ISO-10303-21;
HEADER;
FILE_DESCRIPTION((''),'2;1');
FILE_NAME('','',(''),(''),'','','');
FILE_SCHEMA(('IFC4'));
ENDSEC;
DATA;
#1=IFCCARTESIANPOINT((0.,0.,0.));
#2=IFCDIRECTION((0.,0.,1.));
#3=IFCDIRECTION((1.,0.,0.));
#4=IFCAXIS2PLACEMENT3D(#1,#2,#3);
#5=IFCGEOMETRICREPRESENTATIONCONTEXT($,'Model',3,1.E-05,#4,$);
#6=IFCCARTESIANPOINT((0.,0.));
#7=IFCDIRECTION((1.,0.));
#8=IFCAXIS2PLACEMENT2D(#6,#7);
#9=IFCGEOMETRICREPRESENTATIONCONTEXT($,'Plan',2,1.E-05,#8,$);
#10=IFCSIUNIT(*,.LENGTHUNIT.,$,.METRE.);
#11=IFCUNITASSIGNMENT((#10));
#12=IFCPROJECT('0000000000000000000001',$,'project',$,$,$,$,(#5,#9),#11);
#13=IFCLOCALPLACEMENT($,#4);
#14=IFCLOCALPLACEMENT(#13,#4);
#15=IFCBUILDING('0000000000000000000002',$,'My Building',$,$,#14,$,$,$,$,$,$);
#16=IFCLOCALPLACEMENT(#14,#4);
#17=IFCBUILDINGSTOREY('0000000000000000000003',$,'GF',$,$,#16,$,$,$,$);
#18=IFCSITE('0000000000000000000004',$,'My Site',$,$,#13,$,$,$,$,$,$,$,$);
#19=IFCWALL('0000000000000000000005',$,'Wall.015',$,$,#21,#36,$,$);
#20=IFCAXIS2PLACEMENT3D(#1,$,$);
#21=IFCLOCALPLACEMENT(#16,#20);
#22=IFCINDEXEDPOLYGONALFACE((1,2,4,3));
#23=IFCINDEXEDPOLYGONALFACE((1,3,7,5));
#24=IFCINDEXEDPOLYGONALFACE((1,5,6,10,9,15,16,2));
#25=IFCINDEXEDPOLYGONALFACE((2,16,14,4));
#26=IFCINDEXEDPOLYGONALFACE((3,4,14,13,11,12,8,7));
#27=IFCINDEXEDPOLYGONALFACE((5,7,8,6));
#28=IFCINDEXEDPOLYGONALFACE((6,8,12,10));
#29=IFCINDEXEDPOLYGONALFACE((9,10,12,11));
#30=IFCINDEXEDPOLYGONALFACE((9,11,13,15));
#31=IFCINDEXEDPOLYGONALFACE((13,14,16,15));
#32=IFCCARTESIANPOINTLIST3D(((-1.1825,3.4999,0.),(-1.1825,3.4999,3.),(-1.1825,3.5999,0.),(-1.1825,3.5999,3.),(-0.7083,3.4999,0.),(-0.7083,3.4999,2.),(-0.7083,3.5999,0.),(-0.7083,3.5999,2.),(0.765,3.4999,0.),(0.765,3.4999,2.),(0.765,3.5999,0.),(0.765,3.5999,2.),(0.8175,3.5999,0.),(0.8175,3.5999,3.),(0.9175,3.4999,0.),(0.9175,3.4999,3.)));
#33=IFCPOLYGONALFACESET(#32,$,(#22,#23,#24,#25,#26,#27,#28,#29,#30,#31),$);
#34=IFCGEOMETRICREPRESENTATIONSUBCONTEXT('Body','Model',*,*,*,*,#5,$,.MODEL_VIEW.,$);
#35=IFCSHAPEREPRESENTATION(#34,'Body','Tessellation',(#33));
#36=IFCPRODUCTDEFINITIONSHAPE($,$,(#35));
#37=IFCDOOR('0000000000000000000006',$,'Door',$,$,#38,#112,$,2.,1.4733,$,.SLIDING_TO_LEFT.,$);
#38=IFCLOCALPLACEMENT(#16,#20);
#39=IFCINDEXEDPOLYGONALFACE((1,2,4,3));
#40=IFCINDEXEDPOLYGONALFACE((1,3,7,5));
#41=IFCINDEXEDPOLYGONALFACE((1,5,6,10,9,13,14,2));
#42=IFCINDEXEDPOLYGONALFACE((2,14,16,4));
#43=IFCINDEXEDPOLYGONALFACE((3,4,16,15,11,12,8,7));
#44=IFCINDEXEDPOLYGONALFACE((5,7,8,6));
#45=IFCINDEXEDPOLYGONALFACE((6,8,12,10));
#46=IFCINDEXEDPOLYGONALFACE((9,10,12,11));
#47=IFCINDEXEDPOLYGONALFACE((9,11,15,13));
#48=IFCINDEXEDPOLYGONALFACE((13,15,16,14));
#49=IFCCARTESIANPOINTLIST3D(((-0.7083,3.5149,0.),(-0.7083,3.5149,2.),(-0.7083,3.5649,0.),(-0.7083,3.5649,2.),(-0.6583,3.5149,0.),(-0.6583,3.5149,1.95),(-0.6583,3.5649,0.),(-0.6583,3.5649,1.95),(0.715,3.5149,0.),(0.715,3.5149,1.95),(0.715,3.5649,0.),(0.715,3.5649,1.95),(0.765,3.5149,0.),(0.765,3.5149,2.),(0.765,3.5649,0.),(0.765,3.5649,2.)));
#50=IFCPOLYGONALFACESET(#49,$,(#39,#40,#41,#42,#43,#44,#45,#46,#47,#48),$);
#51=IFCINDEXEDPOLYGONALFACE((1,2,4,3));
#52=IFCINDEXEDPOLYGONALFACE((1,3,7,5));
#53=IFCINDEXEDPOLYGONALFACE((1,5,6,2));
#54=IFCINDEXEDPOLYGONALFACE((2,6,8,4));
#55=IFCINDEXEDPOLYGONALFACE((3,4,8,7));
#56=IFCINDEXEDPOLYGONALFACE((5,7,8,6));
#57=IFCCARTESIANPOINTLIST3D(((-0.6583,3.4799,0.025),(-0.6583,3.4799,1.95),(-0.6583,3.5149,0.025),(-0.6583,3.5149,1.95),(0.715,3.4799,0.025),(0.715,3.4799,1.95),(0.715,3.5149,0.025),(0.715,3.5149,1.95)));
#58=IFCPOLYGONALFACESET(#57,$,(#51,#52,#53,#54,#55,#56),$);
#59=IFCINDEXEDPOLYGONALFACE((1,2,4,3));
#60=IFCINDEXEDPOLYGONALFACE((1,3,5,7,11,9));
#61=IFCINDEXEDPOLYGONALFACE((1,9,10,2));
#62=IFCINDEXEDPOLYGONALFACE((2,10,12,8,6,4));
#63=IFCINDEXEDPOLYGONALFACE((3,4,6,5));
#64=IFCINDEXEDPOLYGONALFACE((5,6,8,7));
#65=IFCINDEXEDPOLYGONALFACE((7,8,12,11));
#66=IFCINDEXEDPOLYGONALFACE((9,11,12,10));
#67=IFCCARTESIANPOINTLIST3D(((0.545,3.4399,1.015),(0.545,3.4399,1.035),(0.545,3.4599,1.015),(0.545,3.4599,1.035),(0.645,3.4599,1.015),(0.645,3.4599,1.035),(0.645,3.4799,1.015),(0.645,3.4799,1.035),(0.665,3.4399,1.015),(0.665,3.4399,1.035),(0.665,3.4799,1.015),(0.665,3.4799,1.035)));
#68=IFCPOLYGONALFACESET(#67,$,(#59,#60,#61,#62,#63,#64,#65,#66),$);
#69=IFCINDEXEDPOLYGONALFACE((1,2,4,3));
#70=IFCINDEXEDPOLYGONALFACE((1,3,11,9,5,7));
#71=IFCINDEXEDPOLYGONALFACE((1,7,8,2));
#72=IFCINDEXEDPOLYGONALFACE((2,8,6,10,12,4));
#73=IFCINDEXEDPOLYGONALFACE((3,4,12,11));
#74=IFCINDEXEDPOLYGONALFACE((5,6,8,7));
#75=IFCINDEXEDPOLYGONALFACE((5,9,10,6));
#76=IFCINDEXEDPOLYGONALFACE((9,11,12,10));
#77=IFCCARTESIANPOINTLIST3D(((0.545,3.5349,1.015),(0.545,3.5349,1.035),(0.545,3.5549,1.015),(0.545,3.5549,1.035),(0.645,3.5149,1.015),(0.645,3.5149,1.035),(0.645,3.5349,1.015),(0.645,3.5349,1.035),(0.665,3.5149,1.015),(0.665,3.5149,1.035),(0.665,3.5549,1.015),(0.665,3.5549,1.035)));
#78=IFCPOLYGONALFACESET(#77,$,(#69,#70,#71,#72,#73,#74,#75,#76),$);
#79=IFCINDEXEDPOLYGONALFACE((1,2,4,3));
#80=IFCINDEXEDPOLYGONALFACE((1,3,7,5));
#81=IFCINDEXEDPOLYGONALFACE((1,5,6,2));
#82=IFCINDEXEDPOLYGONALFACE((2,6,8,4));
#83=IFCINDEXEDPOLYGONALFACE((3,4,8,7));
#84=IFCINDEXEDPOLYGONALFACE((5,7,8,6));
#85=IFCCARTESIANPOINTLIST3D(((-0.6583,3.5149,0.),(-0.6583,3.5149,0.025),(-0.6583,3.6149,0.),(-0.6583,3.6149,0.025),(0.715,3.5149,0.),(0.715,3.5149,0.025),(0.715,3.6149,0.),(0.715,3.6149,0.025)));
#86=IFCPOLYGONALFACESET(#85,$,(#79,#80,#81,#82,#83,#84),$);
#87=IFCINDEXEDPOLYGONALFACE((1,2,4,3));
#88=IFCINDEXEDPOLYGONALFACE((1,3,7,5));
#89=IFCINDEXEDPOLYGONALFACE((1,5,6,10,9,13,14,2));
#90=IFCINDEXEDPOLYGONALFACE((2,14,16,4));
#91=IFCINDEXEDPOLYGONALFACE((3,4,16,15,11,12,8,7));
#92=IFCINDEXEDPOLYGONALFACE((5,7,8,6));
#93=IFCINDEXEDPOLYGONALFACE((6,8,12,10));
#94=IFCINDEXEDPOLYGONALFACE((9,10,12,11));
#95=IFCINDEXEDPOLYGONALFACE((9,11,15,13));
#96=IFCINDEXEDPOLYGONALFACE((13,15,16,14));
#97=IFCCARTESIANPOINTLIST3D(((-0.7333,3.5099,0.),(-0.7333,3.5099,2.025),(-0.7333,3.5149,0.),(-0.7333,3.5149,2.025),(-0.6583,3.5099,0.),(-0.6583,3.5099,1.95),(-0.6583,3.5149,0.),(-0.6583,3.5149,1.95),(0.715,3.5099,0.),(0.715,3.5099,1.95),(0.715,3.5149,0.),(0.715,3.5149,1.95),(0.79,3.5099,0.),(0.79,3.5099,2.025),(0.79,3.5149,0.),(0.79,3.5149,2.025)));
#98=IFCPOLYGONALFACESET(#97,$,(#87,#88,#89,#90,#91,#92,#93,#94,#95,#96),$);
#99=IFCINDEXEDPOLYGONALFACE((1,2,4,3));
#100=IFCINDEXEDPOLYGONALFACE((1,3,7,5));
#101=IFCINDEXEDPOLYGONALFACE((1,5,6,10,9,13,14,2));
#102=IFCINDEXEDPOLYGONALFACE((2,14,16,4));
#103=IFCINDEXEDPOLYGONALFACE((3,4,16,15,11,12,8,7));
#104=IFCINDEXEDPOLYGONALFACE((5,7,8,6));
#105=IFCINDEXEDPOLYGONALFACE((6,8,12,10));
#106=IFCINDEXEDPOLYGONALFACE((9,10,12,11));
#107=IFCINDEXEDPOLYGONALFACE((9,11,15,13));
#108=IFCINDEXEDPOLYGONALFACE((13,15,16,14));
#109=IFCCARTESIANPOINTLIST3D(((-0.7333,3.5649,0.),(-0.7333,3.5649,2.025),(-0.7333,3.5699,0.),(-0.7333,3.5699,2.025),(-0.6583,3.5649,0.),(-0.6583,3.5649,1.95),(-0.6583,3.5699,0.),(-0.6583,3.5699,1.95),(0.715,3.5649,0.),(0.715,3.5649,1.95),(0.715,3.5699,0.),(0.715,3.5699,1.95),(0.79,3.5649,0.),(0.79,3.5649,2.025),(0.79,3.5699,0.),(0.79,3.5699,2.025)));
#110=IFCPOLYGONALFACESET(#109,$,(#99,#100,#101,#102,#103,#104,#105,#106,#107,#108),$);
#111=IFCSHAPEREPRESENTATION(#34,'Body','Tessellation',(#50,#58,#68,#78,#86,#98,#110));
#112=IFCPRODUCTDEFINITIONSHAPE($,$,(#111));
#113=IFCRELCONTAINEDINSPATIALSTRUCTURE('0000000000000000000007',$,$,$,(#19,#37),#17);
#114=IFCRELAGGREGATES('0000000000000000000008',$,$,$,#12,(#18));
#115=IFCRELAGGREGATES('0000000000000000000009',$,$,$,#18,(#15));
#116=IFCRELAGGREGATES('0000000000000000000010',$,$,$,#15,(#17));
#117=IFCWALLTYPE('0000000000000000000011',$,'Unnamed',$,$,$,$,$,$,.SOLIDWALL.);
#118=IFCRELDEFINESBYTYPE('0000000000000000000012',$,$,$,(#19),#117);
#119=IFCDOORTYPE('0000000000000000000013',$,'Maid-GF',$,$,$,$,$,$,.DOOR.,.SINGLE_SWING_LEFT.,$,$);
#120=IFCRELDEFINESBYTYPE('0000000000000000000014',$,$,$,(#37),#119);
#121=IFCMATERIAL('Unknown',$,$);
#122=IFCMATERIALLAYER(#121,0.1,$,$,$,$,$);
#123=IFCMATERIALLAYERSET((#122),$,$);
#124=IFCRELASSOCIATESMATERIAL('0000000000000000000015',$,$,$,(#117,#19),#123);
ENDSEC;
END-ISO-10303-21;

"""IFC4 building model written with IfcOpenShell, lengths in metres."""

from ifc_helpers import new_model, entity, si_unit, frame, origin_with_axes, origin_2d_with_axis, place, context, subcontext, project, spatial, line, indexed_curve, outline, extrude, shape, source, transform, mapped, material, layer, layer_set, layer_usage, type_object, type_shapes, element, fill, save


model = new_model("IFC4")

# Units and contexts
model_context = context("Model", 3, precision=1e-05, world=origin_with_axes())
plan_context = context("Plan", 2, precision=1e-05, world=origin_2d_with_axis())
body_context_1 = subcontext(model_context, "Body", "Model", "MODEL_VIEW")
body_context_2 = subcontext(plan_context, "Body", "Plan", "PLAN_VIEW")
ifc_project = project(units=[si_unit("LENGTHUNIT", "METRE")], contexts=[model_context, plan_context])

# Site, building, storey
site_placement = place(None, origin_with_axes())
site = spatial("IfcSite", under=ifc_project, at=site_placement, Name="My Site")
building_placement = place(site_placement, origin_with_axes())
building = spatial("IfcBuilding", under=site, at=building_placement, Name="My Building")
storey_placement = place(building_placement, origin_with_axes())
storey = spatial("IfcBuildingStorey", under=building, at=storey_placement, Name="GF")

# Shared definitions
ifc_material = material(Name="Unknown")

# Shared definitions
ifc_layer_1 = layer(ifc_material, 0.1)
ifc_layer_set_1 = layer_set([ifc_layer_1])
wall_type = type_object("IfcWallType", Name="Unnamed", PredefinedType="SOLIDWALL", material=ifc_layer_set_1)

# Wall, opening, door
ifc_layer_usage_1 = layer_usage(ifc_layer_set_1, "AXIS2", "POSITIVE", 0.0)
wall_1_placement = place(storey_placement, frame((0.8175, 3.5999, 0.0), z_axis=(0.0, 0.0, 1.0), x_axis=(-1.0, 0.0, 0.0)))
wall_1 = element("IfcWall", 1, at=wall_1_placement, inside=storey, type_object=wall_type, material=ifc_layer_usage_1, Name="Wall.015", context=body_context_1, shape_type="SweptSolid", body=[
    extrude(outline(indexed_curve([(0.0, 0.0), (-0.1, 0.1), (2.0, 0.1), (2.0, 0.0)], segments=[line(1, 2, 3, 4, 1)])), origin_with_axes(), (0.0, 0.0, 1.0), 3.0),
])
shared_shape_1 = source(origin_with_axes(), body_context_1, "Body", "SweptSolid", [
    extrude(outline(indexed_curve([(0.0, 0.0), (1.4733, 0.0), (1.4733, 2.0), (0.0, 2.0)], segments=[line(1, 2, 3, 4, 1)])), frame((0.0, -0.6, 0.0), z_axis=(0.0, -1.0, 0.0), x_axis=(1.0, 0.0, 0.0)), (0.0, 0.0, -1.0), 1.2),
])
opening_1_placement = place(wall_1_placement, frame((1.5258, 0.085, 0.0), z_axis=(0.0, 0.0, 1.0), x_axis=(-1.0, 0.0, 0.0)))
opening_1 = element("IfcOpeningElement", 2, at=opening_1_placement, cuts=wall_1, PredefinedType="OPENING", context=body_context_1, shape_type="MappedRepresentation", body=[
    mapped(shared_shape_1, transform((0.0, 0.0, 0.0), x_axis=(1.0, 0.0, 0.0), y_axis=(0.0, 1.0, 0.0), z_axis=(0.0, 0.0, 1.0), scale=1.0)),
])
door_type_1 = type_object("IfcDoorType", Name="Maid-GF", OperationType="SINGLE_SWING_LEFT", PredefinedType="DOOR")
shared_shape_2 = source(origin_with_axes(), body_context_1, "Body", "SweptSolid", [
    extrude(outline(indexed_curve([(0.0, 0.0), (0.0, 2.0), (1.4733, 2.0), (1.4733, 0.0), (1.4233, 0.0), (1.4233, 1.95), (0.05, 1.95), (0.05, 0.0)], segments=[line(1, 2, 3, 4, 5, 6, 7, 8, 1)])), frame((0.0, 0.0, 0.0), z_axis=(0.0, -1.0, 0.0), x_axis=(1.0, 0.0, 0.0)), (0.0, 0.0, -1.0), 0.05),
    extrude(outline(indexed_curve([(0.0, 0.0), (1.3733, 0.0), (1.3733, 0.035), (0.0, 0.035)], segments=[line(1, 2, 3, 4, 1)])), frame((0.05, -0.035, 0.025), z_axis=(0.0, 0.0, 1.0), x_axis=(1.0, 0.0, 0.0)), (0.0, 0.0, 1.0), 1.925),
    extrude(outline(indexed_curve([(0.0, 0.0), (0.0, -0.04), (-0.12, -0.04), (-0.12, -0.02), (-0.02, -0.02), (-0.02, 0.0)], segments=[line(1, 2, 3, 4, 5, 6, 1)])), frame((1.3733, -0.035, 1.015), z_axis=(0.0, 0.0, 1.0), x_axis=(1.0, 0.0, 0.0)), (0.0, 0.0, 1.0), 0.02),
    extrude(outline(indexed_curve([(0.0, 0.0), (0.0, 0.04), (-0.12, 0.04), (-0.12, 0.02), (-0.02, 0.02), (-0.02, 0.0)], segments=[line(1, 2, 3, 4, 5, 6, 1)])), frame((1.3733, 0.0, 1.015), z_axis=(0.0, 0.0, 1.0), x_axis=(1.0, 0.0, 0.0)), (0.0, 0.0, 1.0), 0.02),
    extrude(outline(indexed_curve([(0.0, 0.0), (1.3733, 0.0), (1.3733, 0.1), (0.0, 0.1)], segments=[line(1, 2, 3, 4, 1)])), frame((0.05, 0.0, 0.0), z_axis=(0.0, 0.0, 1.0), x_axis=(1.0, 0.0, 0.0)), (0.0, 0.0, 1.0), 0.025),
    extrude(outline(indexed_curve([(0.0, 0.0), (0.0, 2.025), (1.5233, 2.025), (1.5233, 0.0), (1.4483, 0.0), (1.4483, 1.95), (0.075, 1.95), (0.075, 0.0)], segments=[line(1, 2, 3, 4, 5, 6, 7, 8, 1)])), frame((-0.025, -0.005, 0.0), z_axis=(0.0, -1.0, 0.0), x_axis=(1.0, 0.0, 0.0)), (0.0, 0.0, -1.0), 0.005),
    extrude(outline(indexed_curve([(0.0, 0.0), (0.0, 2.025), (1.5233, 2.025), (1.5233, 0.0), (1.4483, 0.0), (1.4483, 1.95), (0.075, 1.95), (0.075, 0.0)], segments=[line(1, 2, 3, 4, 5, 6, 7, 8, 1)])), frame((-0.025, 0.05, 0.0), z_axis=(0.0, -1.0, 0.0), x_axis=(1.0, 0.0, 0.0)), (0.0, 0.0, -1.0), 0.005),
])
shared_shape_3 = source(origin_with_axes(), body_context_2, "Body", "Curve2D", [
    entity("IfcIndexedPolyCurve", entity("IfcCartesianPointList2D", [[0.0, 0.0], [0.05, 0.0], [0.05, 0.05], [0.0, 0.05]]), [entity("IfcLineIndex", [1, 2, 3, 4, 1])]),
    entity("IfcIndexedPolyCurve", entity("IfcCartesianPointList2D", [[1.4733, 0.0], [1.4233, 0.0], [1.4233, 0.05], [1.4733, 0.05]]), [entity("IfcLineIndex", [1, 2, 3, 4, 1])]),
    entity("IfcIndexedPolyCurve", entity("IfcCartesianPointList2D", [[-0.6367, -0.035], [0.7367, -0.035], [0.7367, 0.0], [-0.6367, 0.0]]), [entity("IfcLineIndex", [1, 2, 3, 4, 1])]),
])
type_shapes(door_type_1, [shared_shape_2, shared_shape_3])
door_1_placement = place(opening_1_placement, frame((0.0, 0.0, 0.0), z_axis=(0.0, 0.0, 1.0), x_axis=(1.0, 0.0, 0.0)))
door_1 = element("IfcDoor", 3, at=door_1_placement, inside=storey, type_object=door_type_1, Name="Door", OperationType="SLIDING_TO_LEFT", OverallHeight=2.0, OverallWidth=1.4733, shapes=[
    shape(body_context_1, "Body", "MappedRepresentation", [mapped(shared_shape_2, transform((0.0, 0.0, 0.0), x_axis=(1.0, 0.0, 0.0), y_axis=(0.0, 1.0, 0.0), z_axis=(0.0, 0.0, 1.0), scale=1.0))]),
    shape(body_context_2, "Body", "MappedRepresentation", [mapped(shared_shape_3, transform((0.0, 0.0, 0.0), x_axis=(1.0, 0.0, 0.0), y_axis=(0.0, 1.0, 0.0), z_axis=(0.0, 0.0, 1.0), scale=1.0))]),
])
fill(opening_1, door_1)

save(model, "model.ifc")
